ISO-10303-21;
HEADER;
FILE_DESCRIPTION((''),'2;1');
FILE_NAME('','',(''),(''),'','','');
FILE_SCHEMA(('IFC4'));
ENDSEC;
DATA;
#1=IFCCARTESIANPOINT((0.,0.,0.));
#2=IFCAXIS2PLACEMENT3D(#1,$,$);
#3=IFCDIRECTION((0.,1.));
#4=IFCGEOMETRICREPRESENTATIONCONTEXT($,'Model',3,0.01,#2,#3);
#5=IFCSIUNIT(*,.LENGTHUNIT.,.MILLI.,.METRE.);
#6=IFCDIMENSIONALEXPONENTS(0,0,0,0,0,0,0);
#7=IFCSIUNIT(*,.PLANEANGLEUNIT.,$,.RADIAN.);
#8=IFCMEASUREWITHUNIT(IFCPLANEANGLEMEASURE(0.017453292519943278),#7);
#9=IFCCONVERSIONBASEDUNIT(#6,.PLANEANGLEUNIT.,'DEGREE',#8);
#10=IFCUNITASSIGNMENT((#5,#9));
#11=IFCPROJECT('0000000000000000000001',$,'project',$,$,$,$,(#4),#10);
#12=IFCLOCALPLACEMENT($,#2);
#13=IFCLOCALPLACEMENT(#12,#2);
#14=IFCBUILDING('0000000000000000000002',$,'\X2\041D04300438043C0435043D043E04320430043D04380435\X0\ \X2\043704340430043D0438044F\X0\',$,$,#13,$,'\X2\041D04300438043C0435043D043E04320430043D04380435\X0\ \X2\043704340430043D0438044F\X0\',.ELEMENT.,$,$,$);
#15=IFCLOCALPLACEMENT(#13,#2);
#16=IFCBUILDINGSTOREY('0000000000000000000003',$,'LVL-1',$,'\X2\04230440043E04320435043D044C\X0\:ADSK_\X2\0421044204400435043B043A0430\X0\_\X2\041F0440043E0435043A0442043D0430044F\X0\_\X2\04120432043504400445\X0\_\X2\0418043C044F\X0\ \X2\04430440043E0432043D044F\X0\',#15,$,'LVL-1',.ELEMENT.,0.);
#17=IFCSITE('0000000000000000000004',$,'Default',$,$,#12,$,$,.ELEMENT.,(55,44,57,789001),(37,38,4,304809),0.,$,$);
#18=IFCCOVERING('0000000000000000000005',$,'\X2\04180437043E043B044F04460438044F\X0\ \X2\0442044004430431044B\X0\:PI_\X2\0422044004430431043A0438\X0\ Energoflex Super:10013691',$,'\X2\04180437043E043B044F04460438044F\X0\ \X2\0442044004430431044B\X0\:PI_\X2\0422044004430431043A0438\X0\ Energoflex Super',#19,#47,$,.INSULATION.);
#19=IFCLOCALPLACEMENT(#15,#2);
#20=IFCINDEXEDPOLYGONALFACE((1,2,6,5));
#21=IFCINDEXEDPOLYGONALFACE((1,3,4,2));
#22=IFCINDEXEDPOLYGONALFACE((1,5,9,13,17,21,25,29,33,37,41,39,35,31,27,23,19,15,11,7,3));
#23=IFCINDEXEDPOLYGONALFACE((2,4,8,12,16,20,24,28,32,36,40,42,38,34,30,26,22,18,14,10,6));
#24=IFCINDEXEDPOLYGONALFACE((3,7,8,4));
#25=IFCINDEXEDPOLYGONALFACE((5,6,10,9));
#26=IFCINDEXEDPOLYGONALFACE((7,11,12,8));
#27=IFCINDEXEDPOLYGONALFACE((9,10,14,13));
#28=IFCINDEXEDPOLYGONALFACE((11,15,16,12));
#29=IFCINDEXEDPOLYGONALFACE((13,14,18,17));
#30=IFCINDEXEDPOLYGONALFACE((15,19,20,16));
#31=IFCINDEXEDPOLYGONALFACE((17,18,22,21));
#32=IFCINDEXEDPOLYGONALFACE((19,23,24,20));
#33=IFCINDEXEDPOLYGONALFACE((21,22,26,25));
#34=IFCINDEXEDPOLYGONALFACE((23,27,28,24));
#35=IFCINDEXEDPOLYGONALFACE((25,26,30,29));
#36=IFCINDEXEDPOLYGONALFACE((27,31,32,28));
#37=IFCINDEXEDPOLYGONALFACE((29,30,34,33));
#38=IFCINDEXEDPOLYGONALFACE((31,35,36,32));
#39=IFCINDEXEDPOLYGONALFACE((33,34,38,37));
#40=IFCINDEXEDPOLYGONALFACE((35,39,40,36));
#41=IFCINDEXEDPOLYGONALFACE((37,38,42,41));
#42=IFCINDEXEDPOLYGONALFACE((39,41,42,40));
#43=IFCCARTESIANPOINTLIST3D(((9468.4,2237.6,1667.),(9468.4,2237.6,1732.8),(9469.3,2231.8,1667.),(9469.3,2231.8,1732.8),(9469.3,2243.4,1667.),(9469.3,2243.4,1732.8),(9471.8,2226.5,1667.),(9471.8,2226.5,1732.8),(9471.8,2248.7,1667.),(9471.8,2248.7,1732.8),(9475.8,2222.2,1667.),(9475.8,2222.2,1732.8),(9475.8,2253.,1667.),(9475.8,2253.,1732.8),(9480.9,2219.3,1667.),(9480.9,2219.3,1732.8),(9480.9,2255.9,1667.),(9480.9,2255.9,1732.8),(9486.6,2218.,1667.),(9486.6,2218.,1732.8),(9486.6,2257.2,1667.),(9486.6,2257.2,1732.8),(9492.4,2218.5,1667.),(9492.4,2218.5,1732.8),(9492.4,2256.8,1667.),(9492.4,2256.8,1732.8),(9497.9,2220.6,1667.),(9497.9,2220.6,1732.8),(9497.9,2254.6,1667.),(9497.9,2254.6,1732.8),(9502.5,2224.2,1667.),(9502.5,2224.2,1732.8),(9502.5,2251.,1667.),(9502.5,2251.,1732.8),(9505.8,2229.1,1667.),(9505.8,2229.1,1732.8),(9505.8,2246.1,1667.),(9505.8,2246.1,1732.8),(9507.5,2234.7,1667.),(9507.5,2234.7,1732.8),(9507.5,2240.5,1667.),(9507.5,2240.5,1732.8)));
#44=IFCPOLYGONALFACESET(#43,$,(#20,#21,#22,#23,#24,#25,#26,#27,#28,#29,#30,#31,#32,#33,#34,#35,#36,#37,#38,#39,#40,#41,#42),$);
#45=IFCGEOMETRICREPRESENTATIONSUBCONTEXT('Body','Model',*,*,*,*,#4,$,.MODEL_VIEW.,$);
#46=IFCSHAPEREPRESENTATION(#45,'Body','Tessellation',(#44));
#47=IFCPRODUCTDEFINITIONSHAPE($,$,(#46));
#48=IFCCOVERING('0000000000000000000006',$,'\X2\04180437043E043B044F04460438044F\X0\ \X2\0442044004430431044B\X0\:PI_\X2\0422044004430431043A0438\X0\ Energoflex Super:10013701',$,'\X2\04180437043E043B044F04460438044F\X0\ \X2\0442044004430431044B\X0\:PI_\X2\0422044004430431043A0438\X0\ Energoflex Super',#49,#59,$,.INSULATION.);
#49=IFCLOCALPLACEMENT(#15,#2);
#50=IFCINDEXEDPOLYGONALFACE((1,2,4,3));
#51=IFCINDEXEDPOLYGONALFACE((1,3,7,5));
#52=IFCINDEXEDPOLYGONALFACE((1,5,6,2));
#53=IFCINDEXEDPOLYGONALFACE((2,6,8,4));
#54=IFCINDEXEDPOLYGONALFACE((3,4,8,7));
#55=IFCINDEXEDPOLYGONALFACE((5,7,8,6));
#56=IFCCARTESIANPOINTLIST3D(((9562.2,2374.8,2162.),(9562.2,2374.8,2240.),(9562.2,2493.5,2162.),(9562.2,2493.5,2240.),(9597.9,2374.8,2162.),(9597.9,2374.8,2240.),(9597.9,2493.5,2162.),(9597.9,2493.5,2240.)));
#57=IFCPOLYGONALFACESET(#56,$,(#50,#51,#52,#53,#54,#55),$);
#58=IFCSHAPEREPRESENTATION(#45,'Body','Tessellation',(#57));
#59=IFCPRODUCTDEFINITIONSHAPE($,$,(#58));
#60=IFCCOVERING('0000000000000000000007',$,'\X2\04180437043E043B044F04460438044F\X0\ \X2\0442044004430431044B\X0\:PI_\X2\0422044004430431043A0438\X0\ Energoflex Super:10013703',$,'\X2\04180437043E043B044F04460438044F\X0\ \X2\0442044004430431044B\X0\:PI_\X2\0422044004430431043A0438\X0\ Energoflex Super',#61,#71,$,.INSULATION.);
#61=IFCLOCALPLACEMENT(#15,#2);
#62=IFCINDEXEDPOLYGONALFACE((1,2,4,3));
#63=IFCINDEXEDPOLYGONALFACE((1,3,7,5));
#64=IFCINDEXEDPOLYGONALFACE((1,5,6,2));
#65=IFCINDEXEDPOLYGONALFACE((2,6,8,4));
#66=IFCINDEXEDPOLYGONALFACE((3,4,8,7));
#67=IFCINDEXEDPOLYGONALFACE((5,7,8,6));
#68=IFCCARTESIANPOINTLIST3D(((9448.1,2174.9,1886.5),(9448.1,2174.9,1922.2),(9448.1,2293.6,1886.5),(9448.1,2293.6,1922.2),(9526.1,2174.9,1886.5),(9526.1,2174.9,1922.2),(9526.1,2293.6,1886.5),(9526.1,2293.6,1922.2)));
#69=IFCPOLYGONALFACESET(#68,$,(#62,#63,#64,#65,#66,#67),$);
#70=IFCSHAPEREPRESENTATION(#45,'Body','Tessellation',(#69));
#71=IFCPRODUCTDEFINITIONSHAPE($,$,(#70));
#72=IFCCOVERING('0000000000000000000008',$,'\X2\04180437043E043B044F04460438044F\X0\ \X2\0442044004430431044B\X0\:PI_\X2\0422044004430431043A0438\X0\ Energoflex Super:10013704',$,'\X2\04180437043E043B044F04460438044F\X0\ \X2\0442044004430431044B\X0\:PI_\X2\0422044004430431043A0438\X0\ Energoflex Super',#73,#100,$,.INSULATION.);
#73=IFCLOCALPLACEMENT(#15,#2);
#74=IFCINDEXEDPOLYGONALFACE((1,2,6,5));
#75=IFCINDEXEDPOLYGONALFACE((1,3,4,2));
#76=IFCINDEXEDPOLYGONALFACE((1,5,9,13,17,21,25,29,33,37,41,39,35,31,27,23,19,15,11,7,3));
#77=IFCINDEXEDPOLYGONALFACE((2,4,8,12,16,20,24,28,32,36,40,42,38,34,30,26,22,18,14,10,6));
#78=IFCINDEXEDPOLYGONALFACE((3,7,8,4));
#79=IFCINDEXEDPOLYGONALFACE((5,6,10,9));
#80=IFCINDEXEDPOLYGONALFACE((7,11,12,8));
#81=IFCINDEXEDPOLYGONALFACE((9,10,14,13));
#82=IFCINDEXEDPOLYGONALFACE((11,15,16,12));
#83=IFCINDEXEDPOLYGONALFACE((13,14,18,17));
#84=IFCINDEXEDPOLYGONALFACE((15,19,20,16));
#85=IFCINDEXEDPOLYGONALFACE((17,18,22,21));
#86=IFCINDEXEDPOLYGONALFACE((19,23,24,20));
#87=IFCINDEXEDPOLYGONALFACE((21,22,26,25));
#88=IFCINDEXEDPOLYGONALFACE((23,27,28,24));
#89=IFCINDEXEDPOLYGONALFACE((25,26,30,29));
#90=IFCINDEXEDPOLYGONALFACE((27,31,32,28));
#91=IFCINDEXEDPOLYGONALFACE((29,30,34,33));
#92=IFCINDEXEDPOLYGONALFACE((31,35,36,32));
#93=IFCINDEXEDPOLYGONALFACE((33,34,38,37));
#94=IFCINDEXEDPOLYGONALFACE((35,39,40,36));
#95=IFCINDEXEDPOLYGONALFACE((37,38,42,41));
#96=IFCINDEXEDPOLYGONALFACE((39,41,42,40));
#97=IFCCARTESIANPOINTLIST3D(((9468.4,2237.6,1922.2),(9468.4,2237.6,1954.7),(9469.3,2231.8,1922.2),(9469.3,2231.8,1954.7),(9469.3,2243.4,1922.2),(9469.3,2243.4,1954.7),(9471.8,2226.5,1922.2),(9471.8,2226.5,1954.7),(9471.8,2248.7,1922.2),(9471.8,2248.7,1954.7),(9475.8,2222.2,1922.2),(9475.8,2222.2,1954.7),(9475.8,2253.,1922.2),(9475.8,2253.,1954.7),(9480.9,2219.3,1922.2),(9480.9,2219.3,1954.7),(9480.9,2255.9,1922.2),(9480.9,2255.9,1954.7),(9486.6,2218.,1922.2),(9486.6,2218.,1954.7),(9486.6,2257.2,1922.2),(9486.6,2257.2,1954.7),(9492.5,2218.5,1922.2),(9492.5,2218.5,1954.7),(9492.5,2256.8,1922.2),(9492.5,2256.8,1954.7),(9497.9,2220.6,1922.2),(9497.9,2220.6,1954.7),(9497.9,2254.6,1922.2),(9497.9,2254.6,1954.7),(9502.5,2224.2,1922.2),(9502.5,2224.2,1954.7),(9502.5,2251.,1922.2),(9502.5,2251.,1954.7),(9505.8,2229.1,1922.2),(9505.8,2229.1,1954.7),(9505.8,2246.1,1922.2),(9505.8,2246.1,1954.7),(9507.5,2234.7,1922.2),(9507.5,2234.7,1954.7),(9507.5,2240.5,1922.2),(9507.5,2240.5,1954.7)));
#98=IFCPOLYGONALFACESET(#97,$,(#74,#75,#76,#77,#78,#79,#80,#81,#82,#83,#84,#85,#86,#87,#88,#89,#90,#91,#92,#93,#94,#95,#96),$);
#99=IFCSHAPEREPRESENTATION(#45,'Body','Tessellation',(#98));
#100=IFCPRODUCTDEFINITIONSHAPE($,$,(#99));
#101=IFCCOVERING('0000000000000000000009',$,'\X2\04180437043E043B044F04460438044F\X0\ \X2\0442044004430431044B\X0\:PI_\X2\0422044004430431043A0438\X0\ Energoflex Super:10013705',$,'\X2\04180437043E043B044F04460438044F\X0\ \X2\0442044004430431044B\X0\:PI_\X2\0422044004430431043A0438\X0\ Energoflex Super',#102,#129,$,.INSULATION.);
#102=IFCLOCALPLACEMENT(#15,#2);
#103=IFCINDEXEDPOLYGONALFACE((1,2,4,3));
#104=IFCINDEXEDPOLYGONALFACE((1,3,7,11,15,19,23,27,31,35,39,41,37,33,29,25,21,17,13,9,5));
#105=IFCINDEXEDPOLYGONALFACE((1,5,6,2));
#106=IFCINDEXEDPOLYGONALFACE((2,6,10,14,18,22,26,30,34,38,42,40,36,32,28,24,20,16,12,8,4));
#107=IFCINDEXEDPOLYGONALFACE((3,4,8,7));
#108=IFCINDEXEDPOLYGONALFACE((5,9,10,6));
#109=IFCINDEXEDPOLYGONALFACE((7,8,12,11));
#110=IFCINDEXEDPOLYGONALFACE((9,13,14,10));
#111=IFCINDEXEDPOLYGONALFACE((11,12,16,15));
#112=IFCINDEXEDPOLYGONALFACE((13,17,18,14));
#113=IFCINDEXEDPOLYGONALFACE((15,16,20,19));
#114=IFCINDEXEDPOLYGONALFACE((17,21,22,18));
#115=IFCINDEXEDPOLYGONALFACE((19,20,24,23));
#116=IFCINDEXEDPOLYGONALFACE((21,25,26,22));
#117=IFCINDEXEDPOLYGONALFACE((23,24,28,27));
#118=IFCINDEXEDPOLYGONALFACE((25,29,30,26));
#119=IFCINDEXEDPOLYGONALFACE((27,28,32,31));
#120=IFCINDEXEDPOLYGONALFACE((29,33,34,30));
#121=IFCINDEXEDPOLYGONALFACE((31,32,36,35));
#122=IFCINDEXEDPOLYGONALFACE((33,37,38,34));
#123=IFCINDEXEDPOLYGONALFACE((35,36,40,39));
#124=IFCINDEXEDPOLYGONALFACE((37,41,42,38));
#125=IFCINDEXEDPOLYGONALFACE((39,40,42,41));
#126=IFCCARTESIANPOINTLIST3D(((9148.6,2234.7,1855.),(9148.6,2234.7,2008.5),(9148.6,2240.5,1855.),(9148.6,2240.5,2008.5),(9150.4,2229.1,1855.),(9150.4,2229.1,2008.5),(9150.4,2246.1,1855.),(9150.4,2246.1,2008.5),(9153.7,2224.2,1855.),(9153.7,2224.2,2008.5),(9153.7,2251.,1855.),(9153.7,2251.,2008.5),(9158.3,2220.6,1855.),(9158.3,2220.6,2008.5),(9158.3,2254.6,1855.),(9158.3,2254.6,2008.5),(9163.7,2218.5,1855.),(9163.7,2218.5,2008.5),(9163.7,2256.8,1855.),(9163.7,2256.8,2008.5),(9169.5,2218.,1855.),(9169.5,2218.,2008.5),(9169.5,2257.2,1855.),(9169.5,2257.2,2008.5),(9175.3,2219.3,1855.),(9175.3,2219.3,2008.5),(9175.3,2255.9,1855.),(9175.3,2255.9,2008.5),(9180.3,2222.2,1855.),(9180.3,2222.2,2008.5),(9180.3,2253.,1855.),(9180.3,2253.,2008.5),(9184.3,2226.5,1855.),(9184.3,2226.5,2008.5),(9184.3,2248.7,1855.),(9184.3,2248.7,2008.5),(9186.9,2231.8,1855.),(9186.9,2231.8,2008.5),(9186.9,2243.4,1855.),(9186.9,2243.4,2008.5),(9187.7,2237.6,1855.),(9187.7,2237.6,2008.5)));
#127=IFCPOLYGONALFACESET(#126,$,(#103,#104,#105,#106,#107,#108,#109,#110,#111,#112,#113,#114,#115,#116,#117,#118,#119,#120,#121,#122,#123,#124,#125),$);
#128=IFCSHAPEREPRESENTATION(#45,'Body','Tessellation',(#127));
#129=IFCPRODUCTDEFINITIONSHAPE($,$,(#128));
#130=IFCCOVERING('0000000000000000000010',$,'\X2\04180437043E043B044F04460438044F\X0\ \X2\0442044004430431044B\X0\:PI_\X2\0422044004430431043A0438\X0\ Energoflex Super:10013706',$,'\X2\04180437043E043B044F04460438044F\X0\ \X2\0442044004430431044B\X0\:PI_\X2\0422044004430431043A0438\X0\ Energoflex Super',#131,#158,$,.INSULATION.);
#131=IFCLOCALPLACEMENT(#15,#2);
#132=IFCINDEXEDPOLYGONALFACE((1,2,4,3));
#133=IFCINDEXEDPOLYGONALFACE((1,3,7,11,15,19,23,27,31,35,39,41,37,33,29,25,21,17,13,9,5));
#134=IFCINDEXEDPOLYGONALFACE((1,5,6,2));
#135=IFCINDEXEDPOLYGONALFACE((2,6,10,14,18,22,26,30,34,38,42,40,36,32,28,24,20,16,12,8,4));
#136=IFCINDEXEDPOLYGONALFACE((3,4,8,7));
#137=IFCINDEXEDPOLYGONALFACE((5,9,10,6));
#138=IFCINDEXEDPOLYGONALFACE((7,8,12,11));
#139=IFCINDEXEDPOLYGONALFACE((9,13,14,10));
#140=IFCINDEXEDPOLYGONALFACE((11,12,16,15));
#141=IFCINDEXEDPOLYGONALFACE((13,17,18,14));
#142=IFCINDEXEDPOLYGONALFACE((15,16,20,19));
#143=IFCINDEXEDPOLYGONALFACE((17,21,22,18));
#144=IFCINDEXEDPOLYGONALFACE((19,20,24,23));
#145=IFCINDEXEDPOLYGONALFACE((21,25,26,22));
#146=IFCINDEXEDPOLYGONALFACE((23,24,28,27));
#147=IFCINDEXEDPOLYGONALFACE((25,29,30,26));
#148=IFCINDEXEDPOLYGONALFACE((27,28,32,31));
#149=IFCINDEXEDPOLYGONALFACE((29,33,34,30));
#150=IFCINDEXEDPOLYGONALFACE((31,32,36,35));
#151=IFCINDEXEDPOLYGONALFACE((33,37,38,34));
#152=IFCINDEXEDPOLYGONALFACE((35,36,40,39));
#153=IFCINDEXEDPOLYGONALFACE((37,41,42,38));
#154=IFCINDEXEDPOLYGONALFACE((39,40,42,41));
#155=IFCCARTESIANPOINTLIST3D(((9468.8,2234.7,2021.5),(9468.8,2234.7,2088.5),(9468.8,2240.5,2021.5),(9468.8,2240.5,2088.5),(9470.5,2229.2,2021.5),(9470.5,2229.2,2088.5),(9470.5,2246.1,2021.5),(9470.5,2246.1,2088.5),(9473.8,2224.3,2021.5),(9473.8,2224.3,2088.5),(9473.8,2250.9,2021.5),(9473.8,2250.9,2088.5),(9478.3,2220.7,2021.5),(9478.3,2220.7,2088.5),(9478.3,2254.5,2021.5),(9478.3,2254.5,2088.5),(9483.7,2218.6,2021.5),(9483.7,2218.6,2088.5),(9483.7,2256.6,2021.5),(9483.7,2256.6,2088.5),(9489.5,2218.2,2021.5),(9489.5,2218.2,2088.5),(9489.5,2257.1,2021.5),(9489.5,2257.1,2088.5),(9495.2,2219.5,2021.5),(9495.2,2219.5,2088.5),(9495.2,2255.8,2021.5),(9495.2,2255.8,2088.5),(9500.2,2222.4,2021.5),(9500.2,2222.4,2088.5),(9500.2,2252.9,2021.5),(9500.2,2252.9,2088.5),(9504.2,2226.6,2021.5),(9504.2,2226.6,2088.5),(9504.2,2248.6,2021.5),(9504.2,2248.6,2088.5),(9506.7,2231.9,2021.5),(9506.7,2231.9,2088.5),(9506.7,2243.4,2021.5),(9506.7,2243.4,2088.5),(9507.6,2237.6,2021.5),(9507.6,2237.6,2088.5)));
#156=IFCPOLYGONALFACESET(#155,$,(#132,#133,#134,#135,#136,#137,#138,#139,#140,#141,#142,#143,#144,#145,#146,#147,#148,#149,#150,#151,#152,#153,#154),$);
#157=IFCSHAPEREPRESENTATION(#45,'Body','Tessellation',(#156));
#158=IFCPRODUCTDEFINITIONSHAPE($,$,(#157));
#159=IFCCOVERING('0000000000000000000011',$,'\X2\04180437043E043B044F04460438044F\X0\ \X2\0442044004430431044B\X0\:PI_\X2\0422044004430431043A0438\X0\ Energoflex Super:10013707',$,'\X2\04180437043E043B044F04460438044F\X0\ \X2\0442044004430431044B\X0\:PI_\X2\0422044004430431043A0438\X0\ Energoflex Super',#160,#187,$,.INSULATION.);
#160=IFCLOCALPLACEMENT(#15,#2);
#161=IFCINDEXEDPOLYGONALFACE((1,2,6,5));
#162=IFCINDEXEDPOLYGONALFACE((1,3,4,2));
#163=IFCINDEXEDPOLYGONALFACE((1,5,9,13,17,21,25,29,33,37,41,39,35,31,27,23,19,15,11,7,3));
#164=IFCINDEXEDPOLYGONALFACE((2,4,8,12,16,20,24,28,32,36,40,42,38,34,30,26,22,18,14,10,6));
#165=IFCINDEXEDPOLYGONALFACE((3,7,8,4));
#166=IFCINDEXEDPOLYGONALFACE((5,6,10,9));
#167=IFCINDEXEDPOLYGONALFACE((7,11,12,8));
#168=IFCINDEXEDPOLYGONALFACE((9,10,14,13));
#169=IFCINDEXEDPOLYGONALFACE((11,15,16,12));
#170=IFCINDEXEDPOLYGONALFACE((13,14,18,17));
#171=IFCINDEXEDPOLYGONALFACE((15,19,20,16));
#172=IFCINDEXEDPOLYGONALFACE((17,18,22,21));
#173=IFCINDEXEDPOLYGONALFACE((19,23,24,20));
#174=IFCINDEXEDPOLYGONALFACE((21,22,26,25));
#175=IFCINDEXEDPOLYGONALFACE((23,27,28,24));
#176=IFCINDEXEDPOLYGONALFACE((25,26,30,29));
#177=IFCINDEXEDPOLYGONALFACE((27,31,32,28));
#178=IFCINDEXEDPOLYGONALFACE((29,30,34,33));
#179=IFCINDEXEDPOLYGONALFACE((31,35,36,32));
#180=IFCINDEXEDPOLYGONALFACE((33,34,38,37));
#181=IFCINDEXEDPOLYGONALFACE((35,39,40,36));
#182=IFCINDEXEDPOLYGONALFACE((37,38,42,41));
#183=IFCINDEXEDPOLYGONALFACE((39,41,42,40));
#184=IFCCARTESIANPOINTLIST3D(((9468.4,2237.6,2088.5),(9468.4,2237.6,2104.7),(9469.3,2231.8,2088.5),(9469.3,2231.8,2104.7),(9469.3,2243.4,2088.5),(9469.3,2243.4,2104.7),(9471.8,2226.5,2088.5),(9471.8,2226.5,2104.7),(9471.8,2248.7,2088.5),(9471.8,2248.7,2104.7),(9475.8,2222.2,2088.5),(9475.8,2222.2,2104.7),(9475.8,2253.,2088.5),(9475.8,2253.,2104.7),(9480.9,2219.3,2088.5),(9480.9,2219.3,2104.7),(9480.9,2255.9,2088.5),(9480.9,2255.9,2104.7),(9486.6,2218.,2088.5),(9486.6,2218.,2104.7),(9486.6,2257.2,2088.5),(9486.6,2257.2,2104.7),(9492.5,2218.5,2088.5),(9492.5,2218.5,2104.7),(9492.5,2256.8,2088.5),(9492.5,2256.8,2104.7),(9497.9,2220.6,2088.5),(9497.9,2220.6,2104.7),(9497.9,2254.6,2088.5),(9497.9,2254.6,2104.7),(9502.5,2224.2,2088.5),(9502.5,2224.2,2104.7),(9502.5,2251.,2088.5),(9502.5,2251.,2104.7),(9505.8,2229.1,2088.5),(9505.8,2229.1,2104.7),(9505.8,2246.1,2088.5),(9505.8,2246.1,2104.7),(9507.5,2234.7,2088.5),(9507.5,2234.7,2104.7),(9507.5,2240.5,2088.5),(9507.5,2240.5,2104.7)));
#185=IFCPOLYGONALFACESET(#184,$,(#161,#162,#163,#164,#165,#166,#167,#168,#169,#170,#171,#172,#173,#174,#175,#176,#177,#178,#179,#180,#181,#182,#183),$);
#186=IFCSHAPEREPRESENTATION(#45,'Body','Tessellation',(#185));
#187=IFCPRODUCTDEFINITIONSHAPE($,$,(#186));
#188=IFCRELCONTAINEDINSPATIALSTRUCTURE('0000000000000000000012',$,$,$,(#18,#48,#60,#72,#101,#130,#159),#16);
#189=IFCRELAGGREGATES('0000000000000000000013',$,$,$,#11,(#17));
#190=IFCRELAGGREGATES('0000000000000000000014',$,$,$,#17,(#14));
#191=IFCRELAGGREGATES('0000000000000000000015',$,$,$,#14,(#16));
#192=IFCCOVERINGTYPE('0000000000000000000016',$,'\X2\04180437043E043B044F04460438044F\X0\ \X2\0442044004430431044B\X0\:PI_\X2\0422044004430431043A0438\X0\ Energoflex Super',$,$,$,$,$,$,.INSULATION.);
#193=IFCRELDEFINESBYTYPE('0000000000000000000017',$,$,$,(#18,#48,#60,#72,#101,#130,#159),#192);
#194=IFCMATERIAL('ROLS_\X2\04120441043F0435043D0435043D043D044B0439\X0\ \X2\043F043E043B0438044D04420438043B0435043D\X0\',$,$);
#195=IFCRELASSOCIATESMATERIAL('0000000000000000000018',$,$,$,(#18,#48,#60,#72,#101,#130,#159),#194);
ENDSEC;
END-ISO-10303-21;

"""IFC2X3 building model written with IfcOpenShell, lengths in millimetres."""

from ifc_helpers import new_model, entity, si_unit, converted_unit, direction, frame, frame_2d, origin, origin_2d_with_axis, place, context, subcontext, project, spatial, rectangle, circle, extrude, material, type_object, element, save


model = new_model("IFC2X3")

# Units and contexts
model_context = context("Model", 3, precision=0.01, world=origin(), true_north=direction((0.0, 1.0)))
body_context = subcontext(model_context, "Body", "Model", "MODEL_VIEW")
ifc_project = project(units=[si_unit("LENGTHUNIT", "METRE", prefix="MILLI"), converted_unit("PLANEANGLEUNIT", "DEGREE", entity("IfcPlaneAngleMeasure", 0.017453292519943278), si_unit("PLANEANGLEUNIT", "RADIAN"), dimensions=[0, 0, 0, 0, 0, 0, 0])], contexts=[model_context])

# Site, building, storey
site_placement = place(None, origin())
site = spatial("IfcSite", under=ifc_project, at=site_placement, Name="Default", CompositionType="ELEMENT", RefLatitude=(55, 44, 57, 789001), RefLongitude=(37, 38, 4, 304809), RefElevation=0.0)
building_placement = place(site_placement, origin())
building = spatial("IfcBuilding", under=site, at=building_placement, Name="Наименование здания", LongName="Наименование здания", CompositionType="ELEMENT")
storey_placement = place(building_placement, origin())
storey = spatial("IfcBuildingStorey", under=building, at=storey_placement, Name="LVL-1", ObjectType="Уровень:ADSK_Стрелка_Проектная_Вверх_Имя уровня", LongName="LVL-1", CompositionType="ELEMENT", Elevation=0.0)

# Coverings
ifc_material = material(Name="ROLS_Вспененный полиэтилен")
covering_type = type_object("IfcCoveringType", Name="Изоляция трубы:PI_Трубки Energoflex Super", PredefinedType="INSULATION")
covering_1_placement = place(storey_placement, origin())
element("IfcCovering", 1, at=covering_1_placement, inside=storey, type_object=covering_type, material=ifc_material, Name="Изоляция трубы:PI_Трубки Energoflex Super:10013691", ObjectType="Изоляция трубы:PI_Трубки Energoflex Super", PredefinedType="INSULATION", context=body_context, shape_type="SweptSolid", body=[
    extrude(circle(Radius=19.6, at=frame_2d((0.0, 0.0), x_axis=(1.0, 0.0))), frame((9488.0, 2237.6, 1667.0), z_axis=(0.0, 0.0, 1.0), x_axis=(-1.0, 0.0, 0.0)), (0.0, 0.0, 1.0), 65.8),
])
covering_2_placement = place(storey_placement, origin())
element("IfcCovering", 2, at=covering_2_placement, inside=storey, type_object=covering_type, material=ifc_material, Name="Изоляция трубы:PI_Трубки Energoflex Super:10013701", ObjectType="Изоляция трубы:PI_Трубки Energoflex Super", PredefinedType="INSULATION", context=body_context, shape_type="SweptSolid", body=[
    extrude(rectangle(XDim=118.7, YDim=35.7, at=frame_2d((0.0, 0.0), x_axis=(1.0, 0.0))), frame((9580.1, 2434.1, 2162.0), z_axis=(0.0, 0.0, 1.0), x_axis=(0.0, -1.0, 0.0)), (0.0, 0.0, 1.0), 78.0),
])
covering_3_placement = place(storey_placement, origin())
element("IfcCovering", 3, at=covering_3_placement, inside=storey, type_object=covering_type, material=ifc_material, Name="Изоляция трубы:PI_Трубки Energoflex Super:10013703", ObjectType="Изоляция трубы:PI_Трубки Energoflex Super", PredefinedType="INSULATION", context=body_context, shape_type="SweptSolid", body=[
    extrude(rectangle(XDim=118.7, YDim=78.0, at=frame_2d((0.0, 0.0), x_axis=(1.0, 0.0))), frame((9487.1, 2234.2, 1886.5), z_axis=(0.0, 0.0, 1.0), x_axis=(0.0, 1.0, 0.0)), (0.0, 0.0, 1.0), 35.7),
])
covering_4_placement = place(storey_placement, origin())
element("IfcCovering", 4, at=covering_4_placement, inside=storey, type_object=covering_type, material=ifc_material, Name="Изоляция трубы:PI_Трубки Energoflex Super:10013704", ObjectType="Изоляция трубы:PI_Трубки Energoflex Super", PredefinedType="INSULATION", context=body_context, shape_type="SweptSolid", body=[
    extrude(circle(Radius=19.6, at=origin_2d_with_axis()), frame((9488.1, 2237.6, 1922.2), z_axis=(0.0, 0.0, 1.0), x_axis=(-1.0, 0.0, 0.0)), (0.0, 0.0, 1.0), 32.5),
])
covering_5_placement = place(storey_placement, origin())
element("IfcCovering", 5, at=covering_5_placement, inside=storey, type_object=covering_type, material=ifc_material, Name="Изоляция трубы:PI_Трубки Energoflex Super:10013705", ObjectType="Изоляция трубы:PI_Трубки Energoflex Super", PredefinedType="INSULATION", context=body_context, shape_type="SweptSolid", body=[
    extrude(circle(Radius=19.6, at=origin_2d_with_axis()), frame((9168.1, 2237.6, 1855.0)), (0.0, 0.0, 1.0), 153.5),
])
covering_6_placement = place(storey_placement, origin())
element("IfcCovering", 6, at=covering_6_placement, inside=storey, type_object=covering_type, material=ifc_material, Name="Изоляция трубы:PI_Трубки Energoflex Super:10013706", ObjectType="Изоляция трубы:PI_Трубки Energoflex Super", PredefinedType="INSULATION", context=body_context, shape_type="SweptSolid", body=[
    extrude(circle(Radius=19.5, at=origin_2d_with_axis()), frame((9488.1, 2237.6, 2021.5)), (0.0, 0.0, 1.0), 67.0),
])
covering_7_placement = place(storey_placement, origin())
element("IfcCovering", 7, at=covering_7_placement, inside=storey, type_object=covering_type, material=ifc_material, Name="Изоляция трубы:PI_Трубки Energoflex Super:10013707", ObjectType="Изоляция трубы:PI_Трубки Energoflex Super", PredefinedType="INSULATION", context=body_context, shape_type="SweptSolid", body=[
    extrude(circle(Radius=19.6, at=frame_2d((0.0, 0.0), x_axis=(1.0, 0.0))), frame((9488.1, 2237.6, 2088.5), z_axis=(0.0, 0.0, 1.0), x_axis=(-1.0, 0.0, 0.0)), (0.0, 0.0, 1.0), 16.2),
])

save(model, "model.ifc")
